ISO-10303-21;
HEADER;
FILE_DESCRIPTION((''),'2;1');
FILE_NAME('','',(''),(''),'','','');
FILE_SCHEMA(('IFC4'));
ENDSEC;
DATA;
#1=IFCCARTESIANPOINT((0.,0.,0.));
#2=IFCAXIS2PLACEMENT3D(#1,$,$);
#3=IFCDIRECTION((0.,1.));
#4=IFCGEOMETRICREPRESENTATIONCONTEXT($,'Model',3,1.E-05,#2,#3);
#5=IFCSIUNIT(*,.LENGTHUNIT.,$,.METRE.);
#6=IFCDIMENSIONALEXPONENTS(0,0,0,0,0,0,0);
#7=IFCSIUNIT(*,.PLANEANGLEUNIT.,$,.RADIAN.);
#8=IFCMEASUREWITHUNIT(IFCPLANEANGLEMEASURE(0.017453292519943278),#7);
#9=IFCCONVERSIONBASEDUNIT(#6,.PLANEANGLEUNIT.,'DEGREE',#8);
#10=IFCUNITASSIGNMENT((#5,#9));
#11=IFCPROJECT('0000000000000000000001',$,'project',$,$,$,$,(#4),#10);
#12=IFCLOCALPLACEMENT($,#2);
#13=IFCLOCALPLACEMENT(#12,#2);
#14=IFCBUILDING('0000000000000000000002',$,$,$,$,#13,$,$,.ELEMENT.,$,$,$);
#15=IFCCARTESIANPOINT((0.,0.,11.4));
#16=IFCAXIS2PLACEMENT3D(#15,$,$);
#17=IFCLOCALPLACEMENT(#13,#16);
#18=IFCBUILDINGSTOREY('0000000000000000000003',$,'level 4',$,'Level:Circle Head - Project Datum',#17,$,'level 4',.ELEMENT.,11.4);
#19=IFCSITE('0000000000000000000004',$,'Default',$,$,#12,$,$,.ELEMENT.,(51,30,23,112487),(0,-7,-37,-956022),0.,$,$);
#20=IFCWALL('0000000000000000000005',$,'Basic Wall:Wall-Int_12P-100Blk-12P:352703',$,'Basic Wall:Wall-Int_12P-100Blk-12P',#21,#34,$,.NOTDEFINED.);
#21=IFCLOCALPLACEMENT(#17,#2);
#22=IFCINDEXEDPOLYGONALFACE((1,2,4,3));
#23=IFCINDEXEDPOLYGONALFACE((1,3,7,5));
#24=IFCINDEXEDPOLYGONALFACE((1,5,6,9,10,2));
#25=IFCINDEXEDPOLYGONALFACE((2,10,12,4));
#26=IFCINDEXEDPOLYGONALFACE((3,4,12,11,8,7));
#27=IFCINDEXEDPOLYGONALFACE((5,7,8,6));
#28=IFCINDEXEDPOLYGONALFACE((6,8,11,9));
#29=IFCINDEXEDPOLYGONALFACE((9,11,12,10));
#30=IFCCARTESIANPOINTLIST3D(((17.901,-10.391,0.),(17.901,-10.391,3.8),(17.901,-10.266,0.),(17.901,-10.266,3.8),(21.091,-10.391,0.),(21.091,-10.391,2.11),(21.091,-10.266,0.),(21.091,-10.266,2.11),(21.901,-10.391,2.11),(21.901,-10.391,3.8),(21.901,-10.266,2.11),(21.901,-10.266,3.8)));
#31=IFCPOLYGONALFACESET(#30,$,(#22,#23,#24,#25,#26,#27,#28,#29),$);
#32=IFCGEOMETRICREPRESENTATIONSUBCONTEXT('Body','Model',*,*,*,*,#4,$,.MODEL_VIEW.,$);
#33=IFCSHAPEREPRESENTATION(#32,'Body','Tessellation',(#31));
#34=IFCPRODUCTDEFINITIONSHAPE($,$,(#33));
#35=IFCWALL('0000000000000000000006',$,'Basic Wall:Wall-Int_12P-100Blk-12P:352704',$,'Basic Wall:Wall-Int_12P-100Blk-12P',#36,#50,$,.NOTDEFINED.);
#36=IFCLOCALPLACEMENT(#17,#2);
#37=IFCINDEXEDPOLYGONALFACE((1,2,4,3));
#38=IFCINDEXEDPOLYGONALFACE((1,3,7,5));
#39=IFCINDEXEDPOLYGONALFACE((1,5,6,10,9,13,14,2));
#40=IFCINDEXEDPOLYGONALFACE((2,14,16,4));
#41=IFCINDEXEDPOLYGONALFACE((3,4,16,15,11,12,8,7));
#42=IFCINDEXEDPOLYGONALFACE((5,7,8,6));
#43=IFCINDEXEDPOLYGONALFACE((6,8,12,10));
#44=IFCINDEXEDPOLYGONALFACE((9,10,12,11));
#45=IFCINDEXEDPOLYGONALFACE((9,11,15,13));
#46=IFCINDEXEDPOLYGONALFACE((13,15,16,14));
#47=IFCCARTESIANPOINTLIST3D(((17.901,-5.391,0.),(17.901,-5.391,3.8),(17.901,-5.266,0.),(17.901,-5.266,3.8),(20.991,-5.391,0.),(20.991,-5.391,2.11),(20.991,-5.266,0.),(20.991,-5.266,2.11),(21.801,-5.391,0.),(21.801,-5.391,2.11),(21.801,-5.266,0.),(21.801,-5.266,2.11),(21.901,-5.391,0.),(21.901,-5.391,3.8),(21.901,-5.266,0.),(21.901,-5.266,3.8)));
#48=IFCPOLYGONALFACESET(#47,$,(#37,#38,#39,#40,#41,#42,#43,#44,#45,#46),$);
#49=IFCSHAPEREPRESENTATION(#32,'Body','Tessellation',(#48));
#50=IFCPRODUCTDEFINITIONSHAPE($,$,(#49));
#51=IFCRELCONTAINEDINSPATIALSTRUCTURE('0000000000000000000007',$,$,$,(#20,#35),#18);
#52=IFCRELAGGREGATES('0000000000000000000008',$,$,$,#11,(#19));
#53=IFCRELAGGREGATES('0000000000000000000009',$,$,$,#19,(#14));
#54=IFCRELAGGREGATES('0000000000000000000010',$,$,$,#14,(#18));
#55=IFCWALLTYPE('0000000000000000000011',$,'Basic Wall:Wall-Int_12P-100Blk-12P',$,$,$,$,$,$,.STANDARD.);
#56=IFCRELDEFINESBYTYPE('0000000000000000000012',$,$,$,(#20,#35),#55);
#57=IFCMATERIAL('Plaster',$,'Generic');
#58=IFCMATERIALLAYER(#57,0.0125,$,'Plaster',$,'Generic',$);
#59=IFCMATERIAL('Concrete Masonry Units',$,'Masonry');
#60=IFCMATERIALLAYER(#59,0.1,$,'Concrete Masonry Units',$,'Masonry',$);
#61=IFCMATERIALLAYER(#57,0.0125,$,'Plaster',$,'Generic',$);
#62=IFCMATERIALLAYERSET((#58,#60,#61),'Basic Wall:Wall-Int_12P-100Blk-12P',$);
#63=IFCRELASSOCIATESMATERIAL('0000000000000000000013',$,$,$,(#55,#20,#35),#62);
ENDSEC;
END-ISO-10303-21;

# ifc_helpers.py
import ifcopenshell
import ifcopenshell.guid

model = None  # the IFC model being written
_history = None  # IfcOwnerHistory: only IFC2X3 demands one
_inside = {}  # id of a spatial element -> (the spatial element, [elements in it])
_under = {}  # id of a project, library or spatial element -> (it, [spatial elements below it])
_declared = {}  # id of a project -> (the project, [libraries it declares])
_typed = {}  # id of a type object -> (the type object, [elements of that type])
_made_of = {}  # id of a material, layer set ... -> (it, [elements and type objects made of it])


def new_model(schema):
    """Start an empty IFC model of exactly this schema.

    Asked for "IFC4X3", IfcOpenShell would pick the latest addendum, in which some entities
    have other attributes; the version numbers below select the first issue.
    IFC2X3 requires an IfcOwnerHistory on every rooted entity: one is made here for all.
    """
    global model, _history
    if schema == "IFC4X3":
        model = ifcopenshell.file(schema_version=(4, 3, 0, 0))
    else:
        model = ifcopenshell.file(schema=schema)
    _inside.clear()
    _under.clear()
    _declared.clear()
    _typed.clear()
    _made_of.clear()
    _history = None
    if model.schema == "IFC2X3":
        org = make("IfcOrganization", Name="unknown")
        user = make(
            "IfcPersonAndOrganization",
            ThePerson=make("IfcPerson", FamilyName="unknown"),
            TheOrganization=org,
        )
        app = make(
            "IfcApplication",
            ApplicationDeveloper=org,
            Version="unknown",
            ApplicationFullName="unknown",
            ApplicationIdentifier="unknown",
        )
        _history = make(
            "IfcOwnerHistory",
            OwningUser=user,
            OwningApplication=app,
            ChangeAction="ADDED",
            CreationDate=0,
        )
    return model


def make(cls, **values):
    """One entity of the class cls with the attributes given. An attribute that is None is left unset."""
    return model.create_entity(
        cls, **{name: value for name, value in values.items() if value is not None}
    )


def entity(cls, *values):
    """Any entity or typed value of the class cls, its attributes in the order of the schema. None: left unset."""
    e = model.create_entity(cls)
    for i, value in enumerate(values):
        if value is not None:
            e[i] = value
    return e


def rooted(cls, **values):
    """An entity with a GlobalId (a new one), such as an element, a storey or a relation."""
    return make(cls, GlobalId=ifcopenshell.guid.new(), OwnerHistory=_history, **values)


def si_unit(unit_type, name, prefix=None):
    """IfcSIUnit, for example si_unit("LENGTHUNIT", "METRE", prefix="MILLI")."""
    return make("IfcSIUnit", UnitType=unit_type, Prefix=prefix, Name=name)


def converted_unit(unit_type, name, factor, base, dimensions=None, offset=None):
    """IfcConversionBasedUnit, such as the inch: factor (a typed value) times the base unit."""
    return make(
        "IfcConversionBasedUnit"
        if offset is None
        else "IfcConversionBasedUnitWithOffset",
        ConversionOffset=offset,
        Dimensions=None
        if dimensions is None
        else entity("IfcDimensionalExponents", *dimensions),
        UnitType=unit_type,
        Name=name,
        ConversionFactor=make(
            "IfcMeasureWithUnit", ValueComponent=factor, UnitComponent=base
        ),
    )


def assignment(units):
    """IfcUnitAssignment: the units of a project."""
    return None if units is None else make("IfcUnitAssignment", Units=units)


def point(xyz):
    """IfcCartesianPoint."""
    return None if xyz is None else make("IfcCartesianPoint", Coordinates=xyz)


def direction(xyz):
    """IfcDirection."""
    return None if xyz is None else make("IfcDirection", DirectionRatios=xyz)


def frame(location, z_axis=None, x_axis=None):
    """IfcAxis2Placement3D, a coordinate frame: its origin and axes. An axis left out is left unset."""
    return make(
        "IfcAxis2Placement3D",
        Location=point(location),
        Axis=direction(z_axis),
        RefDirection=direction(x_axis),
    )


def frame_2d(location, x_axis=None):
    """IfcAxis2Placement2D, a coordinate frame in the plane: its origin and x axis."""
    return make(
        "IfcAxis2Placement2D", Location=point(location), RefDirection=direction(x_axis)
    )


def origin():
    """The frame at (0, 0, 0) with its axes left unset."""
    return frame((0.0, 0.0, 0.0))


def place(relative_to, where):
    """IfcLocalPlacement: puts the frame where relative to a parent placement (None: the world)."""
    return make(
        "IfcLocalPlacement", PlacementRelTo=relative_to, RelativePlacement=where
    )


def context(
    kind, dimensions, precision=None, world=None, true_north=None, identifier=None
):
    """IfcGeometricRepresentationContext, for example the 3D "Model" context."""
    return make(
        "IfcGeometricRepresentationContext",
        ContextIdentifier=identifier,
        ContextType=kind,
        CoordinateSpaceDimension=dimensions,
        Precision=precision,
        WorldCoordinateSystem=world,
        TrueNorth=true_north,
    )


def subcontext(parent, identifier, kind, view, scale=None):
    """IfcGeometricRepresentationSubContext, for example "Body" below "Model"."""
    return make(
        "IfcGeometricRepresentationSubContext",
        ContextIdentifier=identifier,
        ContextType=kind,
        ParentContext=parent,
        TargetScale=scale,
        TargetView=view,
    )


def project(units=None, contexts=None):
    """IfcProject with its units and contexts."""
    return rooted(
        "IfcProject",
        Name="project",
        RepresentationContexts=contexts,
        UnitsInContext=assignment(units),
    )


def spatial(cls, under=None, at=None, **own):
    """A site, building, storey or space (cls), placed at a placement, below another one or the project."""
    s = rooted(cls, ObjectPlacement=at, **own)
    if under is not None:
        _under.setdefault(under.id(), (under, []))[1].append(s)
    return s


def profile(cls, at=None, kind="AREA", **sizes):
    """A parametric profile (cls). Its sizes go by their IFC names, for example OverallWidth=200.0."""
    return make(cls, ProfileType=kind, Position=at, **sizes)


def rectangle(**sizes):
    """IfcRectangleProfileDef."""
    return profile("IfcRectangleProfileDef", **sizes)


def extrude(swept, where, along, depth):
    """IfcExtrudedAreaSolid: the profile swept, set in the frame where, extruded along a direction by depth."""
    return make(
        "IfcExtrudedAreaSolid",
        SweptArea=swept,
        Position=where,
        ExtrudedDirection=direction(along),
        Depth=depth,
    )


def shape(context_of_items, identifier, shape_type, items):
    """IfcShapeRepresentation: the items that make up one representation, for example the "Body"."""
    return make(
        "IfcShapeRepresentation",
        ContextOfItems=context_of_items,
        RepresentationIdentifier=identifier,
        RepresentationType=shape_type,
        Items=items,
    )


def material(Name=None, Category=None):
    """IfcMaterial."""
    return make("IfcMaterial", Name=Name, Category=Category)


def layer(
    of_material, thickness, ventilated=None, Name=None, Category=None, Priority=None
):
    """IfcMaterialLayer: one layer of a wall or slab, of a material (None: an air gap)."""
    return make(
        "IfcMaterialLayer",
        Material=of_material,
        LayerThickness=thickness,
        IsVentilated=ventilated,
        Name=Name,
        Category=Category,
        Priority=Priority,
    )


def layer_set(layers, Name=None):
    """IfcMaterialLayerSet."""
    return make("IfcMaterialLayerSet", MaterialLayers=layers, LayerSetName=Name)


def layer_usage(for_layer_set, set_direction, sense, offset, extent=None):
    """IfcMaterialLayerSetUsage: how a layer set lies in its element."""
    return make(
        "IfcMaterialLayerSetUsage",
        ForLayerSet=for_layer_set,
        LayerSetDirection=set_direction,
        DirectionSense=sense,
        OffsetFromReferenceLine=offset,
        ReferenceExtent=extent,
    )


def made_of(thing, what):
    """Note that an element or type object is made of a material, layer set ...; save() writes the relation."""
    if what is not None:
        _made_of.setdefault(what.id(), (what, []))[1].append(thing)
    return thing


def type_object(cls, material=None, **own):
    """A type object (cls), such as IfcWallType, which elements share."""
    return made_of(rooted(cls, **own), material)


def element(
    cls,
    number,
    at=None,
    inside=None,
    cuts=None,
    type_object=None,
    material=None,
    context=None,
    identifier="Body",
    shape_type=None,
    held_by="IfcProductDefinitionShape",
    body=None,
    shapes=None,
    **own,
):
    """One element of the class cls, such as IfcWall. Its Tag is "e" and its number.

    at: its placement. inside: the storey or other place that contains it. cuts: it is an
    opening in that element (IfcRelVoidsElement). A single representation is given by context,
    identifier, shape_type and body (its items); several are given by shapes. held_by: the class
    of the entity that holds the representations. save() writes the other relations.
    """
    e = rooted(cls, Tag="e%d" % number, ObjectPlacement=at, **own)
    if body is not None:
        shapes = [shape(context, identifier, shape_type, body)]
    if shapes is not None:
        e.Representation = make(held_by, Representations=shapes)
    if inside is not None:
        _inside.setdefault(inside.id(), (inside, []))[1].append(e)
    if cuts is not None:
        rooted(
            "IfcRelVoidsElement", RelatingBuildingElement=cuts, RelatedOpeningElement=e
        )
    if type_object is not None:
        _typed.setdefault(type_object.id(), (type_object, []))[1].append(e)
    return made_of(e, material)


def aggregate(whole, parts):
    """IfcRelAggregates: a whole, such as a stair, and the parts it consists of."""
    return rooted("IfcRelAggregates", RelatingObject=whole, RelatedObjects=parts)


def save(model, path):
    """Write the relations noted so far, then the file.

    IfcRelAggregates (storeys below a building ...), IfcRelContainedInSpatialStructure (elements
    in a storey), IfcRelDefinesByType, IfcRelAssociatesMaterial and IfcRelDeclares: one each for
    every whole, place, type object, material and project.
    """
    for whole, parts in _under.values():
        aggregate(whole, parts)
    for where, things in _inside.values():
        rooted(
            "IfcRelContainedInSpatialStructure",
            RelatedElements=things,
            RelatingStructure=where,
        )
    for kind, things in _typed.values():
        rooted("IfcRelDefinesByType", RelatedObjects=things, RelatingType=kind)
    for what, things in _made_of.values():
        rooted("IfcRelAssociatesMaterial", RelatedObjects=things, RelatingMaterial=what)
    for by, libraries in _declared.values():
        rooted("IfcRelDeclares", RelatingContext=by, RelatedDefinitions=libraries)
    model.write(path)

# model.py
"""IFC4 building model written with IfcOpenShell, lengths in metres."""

from ifc_helpers import new_model, entity, si_unit, converted_unit, direction, frame, frame_2d, origin, place, context, subcontext, project, spatial, rectangle, extrude, material, layer, layer_set, layer_usage, type_object, element, save


model = new_model("IFC4")

# Units and contexts
model_context = context("Model", 3, precision=1e-05, world=origin(), true_north=direction((0.0, 1.0)))
body_context = subcontext(model_context, "Body", "Model", "MODEL_VIEW")
ifc_project = project(units=[si_unit("LENGTHUNIT", "METRE"), converted_unit("PLANEANGLEUNIT", "DEGREE", entity("IfcPlaneAngleMeasure", 0.017453292519943278), si_unit("PLANEANGLEUNIT", "RADIAN"), dimensions=[0, 0, 0, 0, 0, 0, 0])], contexts=[model_context])

# Site, building, storey
site_placement = place(None, origin())
site = spatial("IfcSite", under=ifc_project, at=site_placement, Name="Default", CompositionType="ELEMENT", RefLatitude=(51, 30, 23, 112487), RefLongitude=(0, -7, -37, -956022), RefElevation=0.0)
building_placement = place(site_placement, origin())
building = spatial("IfcBuilding", under=site, at=building_placement, CompositionType="ELEMENT")
storey_placement = place(building_placement, frame((0.0, 0.0, 11.4)))
storey = spatial("IfcBuildingStorey", under=building, at=storey_placement, Name="level 4", ObjectType="Level:Circle Head - Project Datum", LongName="level 4", CompositionType="ELEMENT", Elevation=11.4)

# Walls, openings
ifc_material_1 = material(Name="Plaster", Category="Generic")
ifc_layer_1 = layer(ifc_material_1, 0.0125, Name="Plaster", Category="Generic")
ifc_material_2 = material(Name="Concrete Masonry Units", Category="Masonry")
ifc_layer_2 = layer(ifc_material_2, 0.1, Name="Concrete Masonry Units", Category="Masonry")
ifc_layer_3 = layer(ifc_material_1, 0.0125, Name="Plaster", Category="Generic")
ifc_layer_set = layer_set([ifc_layer_1, ifc_layer_2, ifc_layer_3], Name="Basic Wall:Wall-Int_12P-100Blk-12P")
ifc_layer_usage_1 = layer_usage(ifc_layer_set, "AXIS2", "NEGATIVE", 0.0625)
wall_type = type_object("IfcWallType", Name="Basic Wall:Wall-Int_12P-100Blk-12P", PredefinedType="STANDARD", material=ifc_layer_set)
wall_1_placement = place(storey_placement, frame((17.901, -10.3285, 0.0)))
wall_1 = element("IfcWall", 1, at=wall_1_placement, inside=storey, type_object=wall_type, material=ifc_layer_usage_1, Name="Basic Wall:Wall-Int_12P-100Blk-12P:352703", ObjectType="Basic Wall:Wall-Int_12P-100Blk-12P", PredefinedType="NOTDEFINED", context=body_context, shape_type="SweptSolid", body=[
    extrude(rectangle(XDim=4.0, YDim=0.125, at=frame_2d((2.0, 0.0), x_axis=(-1.0, 0.0))), origin(), (0.0, 0.0, 1.0), 3.8),
])
opening_1_placement = place(wall_1_placement, frame((4.0, 0.0625, 0.0)))
element("IfcOpeningElement", 2, at=opening_1_placement, cuts=wall_1, PredefinedType="OPENING", context=body_context, shape_type="SweptSolid", body=[
    extrude(rectangle(XDim=2.11, YDim=0.81, at=frame_2d((1.055, 0.405), x_axis=(1.0, 0.0))), frame((0.0, 0.0, 0.0), z_axis=(0.0, -1.0, 0.0), x_axis=(0.0, 0.0, 1.0)), (0.0, 0.0, 1.0), 0.125),
])
ifc_layer_usage_2 = layer_usage(ifc_layer_set, "AXIS2", "NEGATIVE", 0.0625)
wall_2_placement = place(storey_placement, frame((17.901, -5.3285, 0.0)))
wall_2 = element("IfcWall", 3, at=wall_2_placement, inside=storey, type_object=wall_type, material=ifc_layer_usage_2, Name="Basic Wall:Wall-Int_12P-100Blk-12P:352704", ObjectType="Basic Wall:Wall-Int_12P-100Blk-12P", PredefinedType="NOTDEFINED", context=body_context, shape_type="SweptSolid", body=[
    extrude(rectangle(XDim=4.0, YDim=0.125, at=frame_2d((2.0, 0.0), x_axis=(1.0, 0.0))), origin(), (0.0, 0.0, 1.0), 3.8),
])
opening_2_placement = place(wall_2_placement, frame((3.9, 0.0625, 0.0)))
element("IfcOpeningElement", 4, at=opening_2_placement, cuts=wall_2, PredefinedType="OPENING", context=body_context, shape_type="SweptSolid", body=[
    extrude(rectangle(XDim=2.11, YDim=0.81, at=frame_2d((1.055, 0.405), x_axis=(1.0, 0.0))), frame((0.0, 0.0, 0.0), z_axis=(0.0, -1.0, 0.0), x_axis=(0.0, 0.0, 1.0)), (0.0, 0.0, 1.0), 0.125),
])

save(model, "model.ifc")
